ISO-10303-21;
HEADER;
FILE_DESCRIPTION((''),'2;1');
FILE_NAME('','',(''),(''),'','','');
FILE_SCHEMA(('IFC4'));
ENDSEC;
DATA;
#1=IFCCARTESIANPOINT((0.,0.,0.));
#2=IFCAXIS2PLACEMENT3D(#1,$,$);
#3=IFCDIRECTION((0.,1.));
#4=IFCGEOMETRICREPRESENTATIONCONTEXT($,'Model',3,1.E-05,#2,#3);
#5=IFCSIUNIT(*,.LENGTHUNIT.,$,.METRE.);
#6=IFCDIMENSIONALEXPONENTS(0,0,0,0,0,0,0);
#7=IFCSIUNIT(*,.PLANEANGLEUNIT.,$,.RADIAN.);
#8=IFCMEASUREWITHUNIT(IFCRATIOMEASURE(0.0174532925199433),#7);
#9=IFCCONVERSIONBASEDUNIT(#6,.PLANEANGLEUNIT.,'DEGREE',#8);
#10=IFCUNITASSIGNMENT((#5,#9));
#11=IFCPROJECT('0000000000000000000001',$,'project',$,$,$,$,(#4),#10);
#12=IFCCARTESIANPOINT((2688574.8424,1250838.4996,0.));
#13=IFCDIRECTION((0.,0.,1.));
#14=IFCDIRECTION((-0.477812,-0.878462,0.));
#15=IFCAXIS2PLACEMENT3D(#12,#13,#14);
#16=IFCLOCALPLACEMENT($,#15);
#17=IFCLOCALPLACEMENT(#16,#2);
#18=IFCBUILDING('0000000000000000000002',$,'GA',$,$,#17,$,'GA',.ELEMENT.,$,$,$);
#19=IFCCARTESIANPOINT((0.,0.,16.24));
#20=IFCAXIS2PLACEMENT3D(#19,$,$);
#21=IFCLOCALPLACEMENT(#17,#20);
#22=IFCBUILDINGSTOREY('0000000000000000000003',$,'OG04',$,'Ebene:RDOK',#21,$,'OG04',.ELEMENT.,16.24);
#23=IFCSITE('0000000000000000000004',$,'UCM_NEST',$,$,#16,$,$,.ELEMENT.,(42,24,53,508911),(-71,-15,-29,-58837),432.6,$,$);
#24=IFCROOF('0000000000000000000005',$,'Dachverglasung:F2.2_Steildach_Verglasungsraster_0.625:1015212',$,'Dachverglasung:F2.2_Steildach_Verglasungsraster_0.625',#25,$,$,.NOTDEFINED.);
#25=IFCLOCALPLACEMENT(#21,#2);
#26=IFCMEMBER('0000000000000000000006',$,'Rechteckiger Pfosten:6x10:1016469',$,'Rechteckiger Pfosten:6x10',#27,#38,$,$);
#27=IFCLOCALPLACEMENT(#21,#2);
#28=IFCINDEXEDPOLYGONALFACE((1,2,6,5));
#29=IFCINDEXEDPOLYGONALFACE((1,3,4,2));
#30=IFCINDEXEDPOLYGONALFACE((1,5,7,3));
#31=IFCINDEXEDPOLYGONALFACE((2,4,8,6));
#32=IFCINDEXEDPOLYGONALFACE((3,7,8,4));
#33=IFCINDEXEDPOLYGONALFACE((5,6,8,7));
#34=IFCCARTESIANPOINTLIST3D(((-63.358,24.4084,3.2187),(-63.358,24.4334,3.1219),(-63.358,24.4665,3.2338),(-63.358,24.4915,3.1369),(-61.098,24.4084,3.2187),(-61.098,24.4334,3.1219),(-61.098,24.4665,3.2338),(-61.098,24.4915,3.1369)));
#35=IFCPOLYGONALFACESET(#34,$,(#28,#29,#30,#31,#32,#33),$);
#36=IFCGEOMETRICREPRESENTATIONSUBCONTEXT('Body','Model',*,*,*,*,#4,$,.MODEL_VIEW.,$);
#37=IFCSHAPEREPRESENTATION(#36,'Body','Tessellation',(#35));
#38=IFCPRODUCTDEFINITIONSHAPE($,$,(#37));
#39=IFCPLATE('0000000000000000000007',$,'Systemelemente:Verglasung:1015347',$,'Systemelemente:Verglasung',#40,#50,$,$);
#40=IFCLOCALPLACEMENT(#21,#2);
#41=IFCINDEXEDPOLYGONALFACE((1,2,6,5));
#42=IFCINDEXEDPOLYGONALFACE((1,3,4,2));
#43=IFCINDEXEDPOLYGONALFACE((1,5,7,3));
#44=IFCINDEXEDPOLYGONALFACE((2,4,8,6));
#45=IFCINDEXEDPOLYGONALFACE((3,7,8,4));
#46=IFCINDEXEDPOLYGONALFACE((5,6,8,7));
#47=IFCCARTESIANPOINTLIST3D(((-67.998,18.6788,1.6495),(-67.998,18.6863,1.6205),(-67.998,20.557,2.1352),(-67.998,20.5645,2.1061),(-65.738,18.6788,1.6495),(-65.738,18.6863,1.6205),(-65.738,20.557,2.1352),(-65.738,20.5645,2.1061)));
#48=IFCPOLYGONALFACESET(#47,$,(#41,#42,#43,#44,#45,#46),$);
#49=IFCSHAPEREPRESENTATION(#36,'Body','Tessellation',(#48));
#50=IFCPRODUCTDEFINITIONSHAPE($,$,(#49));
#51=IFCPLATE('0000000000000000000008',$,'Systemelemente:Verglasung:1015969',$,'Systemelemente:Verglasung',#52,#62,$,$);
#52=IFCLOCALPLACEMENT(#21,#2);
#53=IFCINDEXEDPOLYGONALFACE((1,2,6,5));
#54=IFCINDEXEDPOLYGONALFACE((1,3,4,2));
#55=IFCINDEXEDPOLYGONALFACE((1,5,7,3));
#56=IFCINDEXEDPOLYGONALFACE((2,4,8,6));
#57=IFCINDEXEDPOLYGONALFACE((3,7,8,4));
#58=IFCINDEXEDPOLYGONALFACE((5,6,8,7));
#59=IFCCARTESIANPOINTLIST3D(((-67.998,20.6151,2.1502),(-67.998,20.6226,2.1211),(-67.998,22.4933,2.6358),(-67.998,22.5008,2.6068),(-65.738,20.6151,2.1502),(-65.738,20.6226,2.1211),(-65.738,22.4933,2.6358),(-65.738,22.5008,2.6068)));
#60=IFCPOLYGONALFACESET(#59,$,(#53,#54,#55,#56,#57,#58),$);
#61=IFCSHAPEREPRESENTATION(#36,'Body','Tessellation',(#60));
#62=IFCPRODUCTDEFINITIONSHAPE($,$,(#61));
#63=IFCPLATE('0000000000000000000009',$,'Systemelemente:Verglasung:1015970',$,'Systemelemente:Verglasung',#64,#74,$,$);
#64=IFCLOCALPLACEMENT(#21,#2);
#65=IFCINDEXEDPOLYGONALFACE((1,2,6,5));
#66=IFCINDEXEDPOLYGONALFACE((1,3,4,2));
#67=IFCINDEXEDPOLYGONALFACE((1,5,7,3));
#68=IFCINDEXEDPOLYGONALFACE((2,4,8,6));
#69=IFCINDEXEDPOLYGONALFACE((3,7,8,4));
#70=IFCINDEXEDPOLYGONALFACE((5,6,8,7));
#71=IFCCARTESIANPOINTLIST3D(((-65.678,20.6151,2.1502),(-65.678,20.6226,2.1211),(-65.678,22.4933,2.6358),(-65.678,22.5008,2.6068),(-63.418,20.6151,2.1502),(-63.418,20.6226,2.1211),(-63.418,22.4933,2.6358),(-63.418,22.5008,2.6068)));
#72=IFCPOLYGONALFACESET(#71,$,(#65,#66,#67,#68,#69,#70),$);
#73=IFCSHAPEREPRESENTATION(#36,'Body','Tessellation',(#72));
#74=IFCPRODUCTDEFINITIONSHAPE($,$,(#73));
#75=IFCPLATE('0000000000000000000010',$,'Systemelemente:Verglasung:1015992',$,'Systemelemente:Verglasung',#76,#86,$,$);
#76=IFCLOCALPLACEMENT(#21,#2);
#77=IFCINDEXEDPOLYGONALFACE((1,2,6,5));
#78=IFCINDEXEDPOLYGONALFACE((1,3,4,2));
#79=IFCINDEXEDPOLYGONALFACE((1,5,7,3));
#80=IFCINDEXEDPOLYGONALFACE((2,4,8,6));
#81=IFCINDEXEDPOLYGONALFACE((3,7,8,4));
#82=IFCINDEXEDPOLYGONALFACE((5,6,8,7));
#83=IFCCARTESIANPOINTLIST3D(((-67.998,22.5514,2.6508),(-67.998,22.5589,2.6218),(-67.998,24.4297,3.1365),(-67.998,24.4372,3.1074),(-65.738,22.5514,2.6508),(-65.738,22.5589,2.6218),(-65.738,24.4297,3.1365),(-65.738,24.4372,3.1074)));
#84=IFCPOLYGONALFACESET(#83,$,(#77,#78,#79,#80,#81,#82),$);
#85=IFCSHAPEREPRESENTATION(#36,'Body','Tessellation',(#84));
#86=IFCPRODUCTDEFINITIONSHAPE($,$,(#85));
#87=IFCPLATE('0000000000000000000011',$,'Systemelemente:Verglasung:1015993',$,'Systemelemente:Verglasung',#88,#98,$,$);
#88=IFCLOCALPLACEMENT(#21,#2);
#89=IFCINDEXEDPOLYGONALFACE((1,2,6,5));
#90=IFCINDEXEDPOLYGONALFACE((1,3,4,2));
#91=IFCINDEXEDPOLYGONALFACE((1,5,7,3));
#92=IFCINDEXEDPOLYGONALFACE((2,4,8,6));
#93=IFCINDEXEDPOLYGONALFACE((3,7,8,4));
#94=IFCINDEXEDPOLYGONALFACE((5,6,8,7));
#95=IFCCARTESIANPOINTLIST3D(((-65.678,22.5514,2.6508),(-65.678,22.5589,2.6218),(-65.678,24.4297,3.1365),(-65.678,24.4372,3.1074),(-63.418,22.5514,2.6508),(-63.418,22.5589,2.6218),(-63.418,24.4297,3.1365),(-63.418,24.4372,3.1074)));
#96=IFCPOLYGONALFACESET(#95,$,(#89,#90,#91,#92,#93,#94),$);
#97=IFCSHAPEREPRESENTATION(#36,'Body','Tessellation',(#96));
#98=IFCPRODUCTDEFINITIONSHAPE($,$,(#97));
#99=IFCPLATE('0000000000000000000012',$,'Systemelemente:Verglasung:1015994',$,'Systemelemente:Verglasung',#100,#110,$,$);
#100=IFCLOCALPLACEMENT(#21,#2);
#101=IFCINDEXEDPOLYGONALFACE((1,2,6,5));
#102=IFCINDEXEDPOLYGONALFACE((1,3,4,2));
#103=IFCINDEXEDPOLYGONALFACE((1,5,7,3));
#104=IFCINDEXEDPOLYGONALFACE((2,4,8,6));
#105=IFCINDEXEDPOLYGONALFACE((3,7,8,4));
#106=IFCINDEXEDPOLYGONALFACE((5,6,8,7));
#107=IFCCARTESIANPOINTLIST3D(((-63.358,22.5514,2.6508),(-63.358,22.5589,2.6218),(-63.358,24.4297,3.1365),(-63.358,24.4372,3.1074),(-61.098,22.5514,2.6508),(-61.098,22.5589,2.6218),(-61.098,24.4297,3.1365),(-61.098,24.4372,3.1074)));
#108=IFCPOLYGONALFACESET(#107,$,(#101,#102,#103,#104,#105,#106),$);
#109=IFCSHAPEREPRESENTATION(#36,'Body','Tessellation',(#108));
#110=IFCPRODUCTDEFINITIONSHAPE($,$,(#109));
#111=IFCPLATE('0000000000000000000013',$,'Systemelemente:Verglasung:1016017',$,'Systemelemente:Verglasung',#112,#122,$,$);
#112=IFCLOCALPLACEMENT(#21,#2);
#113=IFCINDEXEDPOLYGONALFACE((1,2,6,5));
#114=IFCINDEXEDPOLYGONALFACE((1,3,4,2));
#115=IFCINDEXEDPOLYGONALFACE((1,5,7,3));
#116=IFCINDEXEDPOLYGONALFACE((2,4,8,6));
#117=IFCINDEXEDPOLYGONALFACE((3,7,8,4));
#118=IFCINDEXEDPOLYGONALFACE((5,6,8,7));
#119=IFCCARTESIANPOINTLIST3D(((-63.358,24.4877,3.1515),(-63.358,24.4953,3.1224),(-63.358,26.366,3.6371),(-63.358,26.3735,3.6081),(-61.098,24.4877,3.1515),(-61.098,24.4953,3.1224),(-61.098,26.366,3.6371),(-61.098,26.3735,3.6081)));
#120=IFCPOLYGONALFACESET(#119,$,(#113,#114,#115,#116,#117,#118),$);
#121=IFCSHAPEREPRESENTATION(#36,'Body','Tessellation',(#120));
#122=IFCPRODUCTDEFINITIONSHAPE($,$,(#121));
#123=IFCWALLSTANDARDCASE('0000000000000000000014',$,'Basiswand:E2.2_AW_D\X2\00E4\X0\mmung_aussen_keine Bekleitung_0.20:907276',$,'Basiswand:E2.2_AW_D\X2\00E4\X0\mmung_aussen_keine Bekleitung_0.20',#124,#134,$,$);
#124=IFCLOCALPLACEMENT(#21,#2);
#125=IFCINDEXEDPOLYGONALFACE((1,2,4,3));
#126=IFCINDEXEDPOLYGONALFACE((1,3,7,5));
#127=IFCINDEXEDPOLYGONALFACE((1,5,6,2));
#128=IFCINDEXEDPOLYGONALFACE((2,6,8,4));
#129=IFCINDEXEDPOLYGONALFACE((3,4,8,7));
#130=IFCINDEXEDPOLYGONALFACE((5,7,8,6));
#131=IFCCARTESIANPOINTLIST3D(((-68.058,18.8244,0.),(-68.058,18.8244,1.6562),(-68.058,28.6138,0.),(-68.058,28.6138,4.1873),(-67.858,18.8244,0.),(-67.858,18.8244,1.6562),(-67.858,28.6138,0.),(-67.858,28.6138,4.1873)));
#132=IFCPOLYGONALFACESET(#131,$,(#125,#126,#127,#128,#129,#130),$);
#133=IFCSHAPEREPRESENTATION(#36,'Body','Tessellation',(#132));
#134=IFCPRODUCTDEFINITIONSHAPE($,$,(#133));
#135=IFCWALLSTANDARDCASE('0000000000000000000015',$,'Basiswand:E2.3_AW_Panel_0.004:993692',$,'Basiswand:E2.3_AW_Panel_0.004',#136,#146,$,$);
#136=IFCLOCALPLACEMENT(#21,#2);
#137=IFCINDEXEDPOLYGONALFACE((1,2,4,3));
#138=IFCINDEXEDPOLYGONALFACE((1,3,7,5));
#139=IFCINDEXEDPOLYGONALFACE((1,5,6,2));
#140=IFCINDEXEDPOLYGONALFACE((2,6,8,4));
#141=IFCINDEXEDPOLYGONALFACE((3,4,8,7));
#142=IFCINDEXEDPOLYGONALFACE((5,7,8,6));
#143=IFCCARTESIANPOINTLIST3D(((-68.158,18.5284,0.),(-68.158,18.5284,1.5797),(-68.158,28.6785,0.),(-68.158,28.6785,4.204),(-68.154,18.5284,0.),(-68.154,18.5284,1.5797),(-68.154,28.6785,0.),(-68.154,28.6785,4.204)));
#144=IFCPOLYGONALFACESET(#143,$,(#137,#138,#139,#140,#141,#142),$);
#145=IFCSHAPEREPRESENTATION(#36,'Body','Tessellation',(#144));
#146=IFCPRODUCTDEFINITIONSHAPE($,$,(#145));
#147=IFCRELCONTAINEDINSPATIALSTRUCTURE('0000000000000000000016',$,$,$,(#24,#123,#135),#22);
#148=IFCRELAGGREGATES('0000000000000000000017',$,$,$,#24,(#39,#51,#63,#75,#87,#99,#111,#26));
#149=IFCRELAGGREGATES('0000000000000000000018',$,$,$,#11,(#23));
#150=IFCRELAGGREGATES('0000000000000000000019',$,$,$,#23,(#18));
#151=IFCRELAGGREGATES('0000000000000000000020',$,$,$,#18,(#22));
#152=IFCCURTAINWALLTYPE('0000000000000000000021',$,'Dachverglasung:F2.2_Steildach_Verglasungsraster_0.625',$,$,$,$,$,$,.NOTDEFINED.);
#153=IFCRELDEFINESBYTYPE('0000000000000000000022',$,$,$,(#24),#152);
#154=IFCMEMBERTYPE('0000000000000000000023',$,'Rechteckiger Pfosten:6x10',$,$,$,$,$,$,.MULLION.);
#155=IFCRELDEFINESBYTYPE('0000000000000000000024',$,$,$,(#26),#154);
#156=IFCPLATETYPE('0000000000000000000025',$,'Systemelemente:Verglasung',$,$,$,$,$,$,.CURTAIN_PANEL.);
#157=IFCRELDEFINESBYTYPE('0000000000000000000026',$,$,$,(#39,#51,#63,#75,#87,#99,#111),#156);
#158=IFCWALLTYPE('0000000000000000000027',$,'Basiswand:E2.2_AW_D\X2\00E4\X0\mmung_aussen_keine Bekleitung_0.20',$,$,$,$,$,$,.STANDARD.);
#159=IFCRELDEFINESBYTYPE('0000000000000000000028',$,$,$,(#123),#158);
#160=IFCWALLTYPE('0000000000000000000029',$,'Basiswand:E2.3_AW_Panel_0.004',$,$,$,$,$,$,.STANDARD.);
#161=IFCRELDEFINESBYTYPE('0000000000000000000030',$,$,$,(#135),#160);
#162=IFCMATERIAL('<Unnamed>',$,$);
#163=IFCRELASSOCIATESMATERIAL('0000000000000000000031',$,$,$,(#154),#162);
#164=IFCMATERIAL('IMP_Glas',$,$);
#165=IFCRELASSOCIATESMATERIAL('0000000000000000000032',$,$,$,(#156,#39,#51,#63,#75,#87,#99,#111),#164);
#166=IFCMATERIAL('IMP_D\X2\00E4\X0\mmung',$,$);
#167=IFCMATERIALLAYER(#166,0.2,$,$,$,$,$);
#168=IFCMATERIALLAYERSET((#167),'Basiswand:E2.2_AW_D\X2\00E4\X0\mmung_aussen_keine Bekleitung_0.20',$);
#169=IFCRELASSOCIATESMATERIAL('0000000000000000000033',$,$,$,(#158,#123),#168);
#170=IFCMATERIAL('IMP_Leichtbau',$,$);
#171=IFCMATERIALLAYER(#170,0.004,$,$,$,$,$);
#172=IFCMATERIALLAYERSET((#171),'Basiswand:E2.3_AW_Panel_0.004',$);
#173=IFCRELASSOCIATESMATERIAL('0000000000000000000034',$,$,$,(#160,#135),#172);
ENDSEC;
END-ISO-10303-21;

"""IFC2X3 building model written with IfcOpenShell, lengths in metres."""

from ifc_helpers import new_model, entity, si_unit, converted_unit, direction, frame, frame_2d, origin, origin_2d_with_axis, place, context, subcontext, project, spatial, rectangle, extrude, clip, halfspace, source, transform, mapped, material, layer, layer_set, layer_usage, type_object, type_shapes, element, aggregate, save


model = new_model("IFC2X3")

# Units and contexts
model_context = context("Model", 3, precision=1e-05, world=origin(), true_north=direction((0.0, 1.0)))
body_context = subcontext(model_context, "Body", "Model", "MODEL_VIEW")
ifc_project = project(units=[si_unit("LENGTHUNIT", "METRE"), converted_unit("PLANEANGLEUNIT", "DEGREE", entity("IfcRatioMeasure", 0.0174532925199433), si_unit("PLANEANGLEUNIT", "RADIAN"), dimensions=[0, 0, 0, 0, 0, 0, 0])], contexts=[model_context])

# Site, building, storey
site_placement = place(None, frame((2688574.8424, 1250838.4996, 0.0), z_axis=(0.0, 0.0, 1.0), x_axis=(-0.477812, -0.878462, 0.0)))
site = spatial("IfcSite", under=ifc_project, at=site_placement, Name="UCM_NEST", CompositionType="ELEMENT", RefLatitude=(42, 24, 53, 508911), RefLongitude=(-71, -15, -29, -58837), RefElevation=432.6)
building_placement = place(site_placement, origin())
building = spatial("IfcBuilding", under=site, at=building_placement, Name="GA", LongName="GA", CompositionType="ELEMENT")
storey_placement = place(building_placement, frame((0.0, 0.0, 16.24)))
storey = spatial("IfcBuildingStorey", under=building, at=storey_placement, Name="OG04", ObjectType="Ebene:RDOK", LongName="OG04", CompositionType="ELEMENT", Elevation=16.24)

# Roof, member, plates
curtain_wall_type = type_object("IfcCurtainWallType", Name="Dachverglasung:F2.2_Steildach_Verglasungsraster_0.625", PredefinedType="NOTDEFINED")
roof_placement = place(storey_placement, frame((0.0, 0.0, -16.24)))
roof = element("IfcRoof", 1, at=roof_placement, inside=storey, type_object=curtain_wall_type, Name="Dachverglasung:F2.2_Steildach_Verglasungsraster_0.625:1015212", ObjectType="Dachverglasung:F2.2_Steildach_Verglasungsraster_0.625", ShapeType="NOTDEFINED")
ifc_material_1 = material(Name="<Unnamed>")
member_type_1 = type_object("IfcMemberType", Name="Rechteckiger Pfosten:6x10", PredefinedType="MULLION", material=ifc_material_1)
shared_shape_1 = source(origin(), body_context, "Body", "SweptSolid", [
    extrude(rectangle(XDim=0.1, YDim=0.06, at=origin_2d_with_axis()), frame((-0.03, -0.05, -2.26), z_axis=(0.0, 0.0, 1.0), x_axis=(0.0, -1.0, 0.0)), (0.0, 0.0, 1.0), 2.26),
])
type_shapes(member_type_1, [shared_shape_1])
member_1_placement = place(roof_placement, frame((-63.358, 24.4915, 19.3769), z_axis=(-1.0, 0.0, 0.0), x_axis=(0.0, 0.968163, 0.250322)))
member_1 = element("IfcMember", 2, at=member_1_placement, type_object=member_type_1, Name="Rechteckiger Pfosten:6x10:1016469", ObjectType="Rechteckiger Pfosten:6x10", context=body_context, shape_type="MappedRepresentation", body=[
    mapped(shared_shape_1, transform((0.0, 0.0, 0.0), scale=1.0)),
])
ifc_material_2 = material(Name="IMP_Glas")
plate_type = type_object("IfcPlateType", Name="Systemelemente:Verglasung", PredefinedType="CURTAIN_PANEL", material=ifc_material_2)
shared_shape_2 = source(origin(), body_context, "Body", "SweptSolid", [
    extrude(rectangle(XDim=0.03, YDim=2.26, at=origin_2d_with_axis()), frame((0.0, 0.0, 0.0), z_axis=(0.0, 0.0, 1.0), x_axis=(0.0, 1.0, 0.0)), (0.0, 0.0, 1.0), 1.94),
])
type_shapes(plate_type, [shared_shape_2])
plate_1_placement = place(roof_placement, frame((-66.868, 18.6825, 17.875), z_axis=(0.0, 0.968163, 0.250322), x_axis=(1.0, 0.0, 0.0)))
plate_1 = element("IfcPlate", 3, at=plate_1_placement, type_object=plate_type, material=ifc_material_2, Name="Systemelemente:Verglasung:1015347", ObjectType="Systemelemente:Verglasung", context=body_context, shape_type="MappedRepresentation", body=[
    mapped(shared_shape_2, transform((0.0, 0.0, 0.0), scale=1.0)),
])
plate_2_placement = place(roof_placement, frame((-66.868, 20.6189, 18.3757), z_axis=(0.0, 0.968163, 0.250322), x_axis=(1.0, 0.0, 0.0)))
plate_2 = element("IfcPlate", 4, at=plate_2_placement, type_object=plate_type, material=ifc_material_2, Name="Systemelemente:Verglasung:1015969", ObjectType="Systemelemente:Verglasung", context=body_context, shape_type="MappedRepresentation", body=[
    mapped(shared_shape_2, transform((0.0, 0.0, 0.0), scale=1.0)),
])
plate_3_placement = place(roof_placement, frame((-64.548, 20.6189, 18.3757), z_axis=(0.0, 0.968163, 0.250322), x_axis=(1.0, 0.0, 0.0)))
plate_3 = element("IfcPlate", 5, at=plate_3_placement, type_object=plate_type, material=ifc_material_2, Name="Systemelemente:Verglasung:1015970", ObjectType="Systemelemente:Verglasung", context=body_context, shape_type="MappedRepresentation", body=[
    mapped(shared_shape_2, transform((0.0, 0.0, 0.0), scale=1.0)),
])
plate_4_placement = place(roof_placement, frame((-66.868, 22.5552, 18.8763), z_axis=(0.0, 0.968163, 0.250322), x_axis=(1.0, 0.0, 0.0)))
plate_4 = element("IfcPlate", 6, at=plate_4_placement, type_object=plate_type, material=ifc_material_2, Name="Systemelemente:Verglasung:1015992", ObjectType="Systemelemente:Verglasung", context=body_context, shape_type="MappedRepresentation", body=[
    mapped(shared_shape_2, transform((0.0, 0.0, 0.0), scale=1.0)),
])
plate_5_placement = place(roof_placement, frame((-64.548, 22.5552, 18.8763), z_axis=(0.0, 0.968163, 0.250322), x_axis=(1.0, 0.0, 0.0)))
plate_5 = element("IfcPlate", 7, at=plate_5_placement, type_object=plate_type, material=ifc_material_2, Name="Systemelemente:Verglasung:1015993", ObjectType="Systemelemente:Verglasung", context=body_context, shape_type="MappedRepresentation", body=[
    mapped(shared_shape_2, transform((0.0, 0.0, 0.0), scale=1.0)),
])
plate_6_placement = place(roof_placement, frame((-62.228, 22.5552, 18.8763), z_axis=(0.0, 0.968163, 0.250322), x_axis=(1.0, 0.0, 0.0)))
plate_6 = element("IfcPlate", 8, at=plate_6_placement, type_object=plate_type, material=ifc_material_2, Name="Systemelemente:Verglasung:1015994", ObjectType="Systemelemente:Verglasung", context=body_context, shape_type="MappedRepresentation", body=[
    mapped(shared_shape_2, transform((0.0, 0.0, 0.0), scale=1.0)),
])
plate_7_placement = place(roof_placement, frame((-62.228, 24.4915, 19.3769), z_axis=(0.0, 0.968163, 0.250322), x_axis=(1.0, 0.0, 0.0)))
plate_7 = element("IfcPlate", 9, at=plate_7_placement, type_object=plate_type, material=ifc_material_2, Name="Systemelemente:Verglasung:1016017", ObjectType="Systemelemente:Verglasung", context=body_context, shape_type="MappedRepresentation", body=[
    mapped(shared_shape_2, transform((0.0, 0.0, 0.0), scale=1.0)),
])
aggregate(roof, [plate_1, plate_2, plate_3, plate_4, plate_5, plate_6, plate_7, member_1])

# Wall
ifc_material_3 = material(Name="IMP_Dämmung")
ifc_layer_1 = layer(ifc_material_3, 0.2)
ifc_layer_set_1 = layer_set([ifc_layer_1], Name="Basiswand:E2.2_AW_Dämmung_aussen_keine Bekleitung_0.20")
ifc_layer_usage_1 = layer_usage(ifc_layer_set_1, "AXIS2", "NEGATIVE", 0.1)
wall_type_1 = type_object("IfcWallType", Name="Basiswand:E2.2_AW_Dämmung_aussen_keine Bekleitung_0.20", PredefinedType="STANDARD", material=ifc_layer_set_1)
wall_1_placement = place(storey_placement, frame((-67.958, 18.8244, 0.0), z_axis=(0.0, 0.0, 1.0), x_axis=(0.0, 1.0, 0.0)))
element("IfcWallStandardCase", 10, at=wall_1_placement, inside=storey, type_object=wall_type_1, material=ifc_layer_usage_1, Name="Basiswand:E2.2_AW_Dämmung_aussen_keine Bekleitung_0.20:907276", ObjectType="Basiswand:E2.2_AW_Dämmung_aussen_keine Bekleitung_0.20", context=body_context, shape_type="Clipping", body=[
    clip(extrude(rectangle(XDim=9.7894, YDim=0.2, at=frame_2d((4.8947, 0.0), x_axis=(-1.0, 0.0))), origin(), (0.0, 0.0, 1.0), 4.1873), halfspace(frame((0.0, -0.1, 1.6562), z_axis=(-0.250322, 0.0, 0.968163), x_axis=(0.0, 1.0, 0.0)), False)),
])

# Wall
ifc_material_4 = material(Name="IMP_Leichtbau")
ifc_layer_2 = layer(ifc_material_4, 0.004)
ifc_layer_set_2 = layer_set([ifc_layer_2], Name="Basiswand:E2.3_AW_Panel_0.004")
ifc_layer_usage_2 = layer_usage(ifc_layer_set_2, "AXIS2", "NEGATIVE", 0.002)
wall_type_2 = type_object("IfcWallType", Name="Basiswand:E2.3_AW_Panel_0.004", PredefinedType="STANDARD", material=ifc_layer_set_2)
wall_2_placement = place(storey_placement, frame((-68.156, 18.5284, 0.0), z_axis=(0.0, 0.0, 1.0), x_axis=(0.0, 1.0, 0.0)))
element("IfcWallStandardCase", 11, at=wall_2_placement, inside=storey, type_object=wall_type_2, material=ifc_layer_usage_2, Name="Basiswand:E2.3_AW_Panel_0.004:993692", ObjectType="Basiswand:E2.3_AW_Panel_0.004", context=body_context, shape_type="Clipping", body=[
    clip(extrude(rectangle(XDim=10.1501, YDim=0.004, at=frame_2d((5.075, 0.0), x_axis=(-1.0, 0.0))), origin(), (0.0, 0.0, 1.0), 4.204), halfspace(frame((0.0, -0.002, 1.5797), z_axis=(-0.250322, 0.0, 0.968163), x_axis=(0.0, 1.0, 0.0)), False)),
])

save(model, "model.ifc")
